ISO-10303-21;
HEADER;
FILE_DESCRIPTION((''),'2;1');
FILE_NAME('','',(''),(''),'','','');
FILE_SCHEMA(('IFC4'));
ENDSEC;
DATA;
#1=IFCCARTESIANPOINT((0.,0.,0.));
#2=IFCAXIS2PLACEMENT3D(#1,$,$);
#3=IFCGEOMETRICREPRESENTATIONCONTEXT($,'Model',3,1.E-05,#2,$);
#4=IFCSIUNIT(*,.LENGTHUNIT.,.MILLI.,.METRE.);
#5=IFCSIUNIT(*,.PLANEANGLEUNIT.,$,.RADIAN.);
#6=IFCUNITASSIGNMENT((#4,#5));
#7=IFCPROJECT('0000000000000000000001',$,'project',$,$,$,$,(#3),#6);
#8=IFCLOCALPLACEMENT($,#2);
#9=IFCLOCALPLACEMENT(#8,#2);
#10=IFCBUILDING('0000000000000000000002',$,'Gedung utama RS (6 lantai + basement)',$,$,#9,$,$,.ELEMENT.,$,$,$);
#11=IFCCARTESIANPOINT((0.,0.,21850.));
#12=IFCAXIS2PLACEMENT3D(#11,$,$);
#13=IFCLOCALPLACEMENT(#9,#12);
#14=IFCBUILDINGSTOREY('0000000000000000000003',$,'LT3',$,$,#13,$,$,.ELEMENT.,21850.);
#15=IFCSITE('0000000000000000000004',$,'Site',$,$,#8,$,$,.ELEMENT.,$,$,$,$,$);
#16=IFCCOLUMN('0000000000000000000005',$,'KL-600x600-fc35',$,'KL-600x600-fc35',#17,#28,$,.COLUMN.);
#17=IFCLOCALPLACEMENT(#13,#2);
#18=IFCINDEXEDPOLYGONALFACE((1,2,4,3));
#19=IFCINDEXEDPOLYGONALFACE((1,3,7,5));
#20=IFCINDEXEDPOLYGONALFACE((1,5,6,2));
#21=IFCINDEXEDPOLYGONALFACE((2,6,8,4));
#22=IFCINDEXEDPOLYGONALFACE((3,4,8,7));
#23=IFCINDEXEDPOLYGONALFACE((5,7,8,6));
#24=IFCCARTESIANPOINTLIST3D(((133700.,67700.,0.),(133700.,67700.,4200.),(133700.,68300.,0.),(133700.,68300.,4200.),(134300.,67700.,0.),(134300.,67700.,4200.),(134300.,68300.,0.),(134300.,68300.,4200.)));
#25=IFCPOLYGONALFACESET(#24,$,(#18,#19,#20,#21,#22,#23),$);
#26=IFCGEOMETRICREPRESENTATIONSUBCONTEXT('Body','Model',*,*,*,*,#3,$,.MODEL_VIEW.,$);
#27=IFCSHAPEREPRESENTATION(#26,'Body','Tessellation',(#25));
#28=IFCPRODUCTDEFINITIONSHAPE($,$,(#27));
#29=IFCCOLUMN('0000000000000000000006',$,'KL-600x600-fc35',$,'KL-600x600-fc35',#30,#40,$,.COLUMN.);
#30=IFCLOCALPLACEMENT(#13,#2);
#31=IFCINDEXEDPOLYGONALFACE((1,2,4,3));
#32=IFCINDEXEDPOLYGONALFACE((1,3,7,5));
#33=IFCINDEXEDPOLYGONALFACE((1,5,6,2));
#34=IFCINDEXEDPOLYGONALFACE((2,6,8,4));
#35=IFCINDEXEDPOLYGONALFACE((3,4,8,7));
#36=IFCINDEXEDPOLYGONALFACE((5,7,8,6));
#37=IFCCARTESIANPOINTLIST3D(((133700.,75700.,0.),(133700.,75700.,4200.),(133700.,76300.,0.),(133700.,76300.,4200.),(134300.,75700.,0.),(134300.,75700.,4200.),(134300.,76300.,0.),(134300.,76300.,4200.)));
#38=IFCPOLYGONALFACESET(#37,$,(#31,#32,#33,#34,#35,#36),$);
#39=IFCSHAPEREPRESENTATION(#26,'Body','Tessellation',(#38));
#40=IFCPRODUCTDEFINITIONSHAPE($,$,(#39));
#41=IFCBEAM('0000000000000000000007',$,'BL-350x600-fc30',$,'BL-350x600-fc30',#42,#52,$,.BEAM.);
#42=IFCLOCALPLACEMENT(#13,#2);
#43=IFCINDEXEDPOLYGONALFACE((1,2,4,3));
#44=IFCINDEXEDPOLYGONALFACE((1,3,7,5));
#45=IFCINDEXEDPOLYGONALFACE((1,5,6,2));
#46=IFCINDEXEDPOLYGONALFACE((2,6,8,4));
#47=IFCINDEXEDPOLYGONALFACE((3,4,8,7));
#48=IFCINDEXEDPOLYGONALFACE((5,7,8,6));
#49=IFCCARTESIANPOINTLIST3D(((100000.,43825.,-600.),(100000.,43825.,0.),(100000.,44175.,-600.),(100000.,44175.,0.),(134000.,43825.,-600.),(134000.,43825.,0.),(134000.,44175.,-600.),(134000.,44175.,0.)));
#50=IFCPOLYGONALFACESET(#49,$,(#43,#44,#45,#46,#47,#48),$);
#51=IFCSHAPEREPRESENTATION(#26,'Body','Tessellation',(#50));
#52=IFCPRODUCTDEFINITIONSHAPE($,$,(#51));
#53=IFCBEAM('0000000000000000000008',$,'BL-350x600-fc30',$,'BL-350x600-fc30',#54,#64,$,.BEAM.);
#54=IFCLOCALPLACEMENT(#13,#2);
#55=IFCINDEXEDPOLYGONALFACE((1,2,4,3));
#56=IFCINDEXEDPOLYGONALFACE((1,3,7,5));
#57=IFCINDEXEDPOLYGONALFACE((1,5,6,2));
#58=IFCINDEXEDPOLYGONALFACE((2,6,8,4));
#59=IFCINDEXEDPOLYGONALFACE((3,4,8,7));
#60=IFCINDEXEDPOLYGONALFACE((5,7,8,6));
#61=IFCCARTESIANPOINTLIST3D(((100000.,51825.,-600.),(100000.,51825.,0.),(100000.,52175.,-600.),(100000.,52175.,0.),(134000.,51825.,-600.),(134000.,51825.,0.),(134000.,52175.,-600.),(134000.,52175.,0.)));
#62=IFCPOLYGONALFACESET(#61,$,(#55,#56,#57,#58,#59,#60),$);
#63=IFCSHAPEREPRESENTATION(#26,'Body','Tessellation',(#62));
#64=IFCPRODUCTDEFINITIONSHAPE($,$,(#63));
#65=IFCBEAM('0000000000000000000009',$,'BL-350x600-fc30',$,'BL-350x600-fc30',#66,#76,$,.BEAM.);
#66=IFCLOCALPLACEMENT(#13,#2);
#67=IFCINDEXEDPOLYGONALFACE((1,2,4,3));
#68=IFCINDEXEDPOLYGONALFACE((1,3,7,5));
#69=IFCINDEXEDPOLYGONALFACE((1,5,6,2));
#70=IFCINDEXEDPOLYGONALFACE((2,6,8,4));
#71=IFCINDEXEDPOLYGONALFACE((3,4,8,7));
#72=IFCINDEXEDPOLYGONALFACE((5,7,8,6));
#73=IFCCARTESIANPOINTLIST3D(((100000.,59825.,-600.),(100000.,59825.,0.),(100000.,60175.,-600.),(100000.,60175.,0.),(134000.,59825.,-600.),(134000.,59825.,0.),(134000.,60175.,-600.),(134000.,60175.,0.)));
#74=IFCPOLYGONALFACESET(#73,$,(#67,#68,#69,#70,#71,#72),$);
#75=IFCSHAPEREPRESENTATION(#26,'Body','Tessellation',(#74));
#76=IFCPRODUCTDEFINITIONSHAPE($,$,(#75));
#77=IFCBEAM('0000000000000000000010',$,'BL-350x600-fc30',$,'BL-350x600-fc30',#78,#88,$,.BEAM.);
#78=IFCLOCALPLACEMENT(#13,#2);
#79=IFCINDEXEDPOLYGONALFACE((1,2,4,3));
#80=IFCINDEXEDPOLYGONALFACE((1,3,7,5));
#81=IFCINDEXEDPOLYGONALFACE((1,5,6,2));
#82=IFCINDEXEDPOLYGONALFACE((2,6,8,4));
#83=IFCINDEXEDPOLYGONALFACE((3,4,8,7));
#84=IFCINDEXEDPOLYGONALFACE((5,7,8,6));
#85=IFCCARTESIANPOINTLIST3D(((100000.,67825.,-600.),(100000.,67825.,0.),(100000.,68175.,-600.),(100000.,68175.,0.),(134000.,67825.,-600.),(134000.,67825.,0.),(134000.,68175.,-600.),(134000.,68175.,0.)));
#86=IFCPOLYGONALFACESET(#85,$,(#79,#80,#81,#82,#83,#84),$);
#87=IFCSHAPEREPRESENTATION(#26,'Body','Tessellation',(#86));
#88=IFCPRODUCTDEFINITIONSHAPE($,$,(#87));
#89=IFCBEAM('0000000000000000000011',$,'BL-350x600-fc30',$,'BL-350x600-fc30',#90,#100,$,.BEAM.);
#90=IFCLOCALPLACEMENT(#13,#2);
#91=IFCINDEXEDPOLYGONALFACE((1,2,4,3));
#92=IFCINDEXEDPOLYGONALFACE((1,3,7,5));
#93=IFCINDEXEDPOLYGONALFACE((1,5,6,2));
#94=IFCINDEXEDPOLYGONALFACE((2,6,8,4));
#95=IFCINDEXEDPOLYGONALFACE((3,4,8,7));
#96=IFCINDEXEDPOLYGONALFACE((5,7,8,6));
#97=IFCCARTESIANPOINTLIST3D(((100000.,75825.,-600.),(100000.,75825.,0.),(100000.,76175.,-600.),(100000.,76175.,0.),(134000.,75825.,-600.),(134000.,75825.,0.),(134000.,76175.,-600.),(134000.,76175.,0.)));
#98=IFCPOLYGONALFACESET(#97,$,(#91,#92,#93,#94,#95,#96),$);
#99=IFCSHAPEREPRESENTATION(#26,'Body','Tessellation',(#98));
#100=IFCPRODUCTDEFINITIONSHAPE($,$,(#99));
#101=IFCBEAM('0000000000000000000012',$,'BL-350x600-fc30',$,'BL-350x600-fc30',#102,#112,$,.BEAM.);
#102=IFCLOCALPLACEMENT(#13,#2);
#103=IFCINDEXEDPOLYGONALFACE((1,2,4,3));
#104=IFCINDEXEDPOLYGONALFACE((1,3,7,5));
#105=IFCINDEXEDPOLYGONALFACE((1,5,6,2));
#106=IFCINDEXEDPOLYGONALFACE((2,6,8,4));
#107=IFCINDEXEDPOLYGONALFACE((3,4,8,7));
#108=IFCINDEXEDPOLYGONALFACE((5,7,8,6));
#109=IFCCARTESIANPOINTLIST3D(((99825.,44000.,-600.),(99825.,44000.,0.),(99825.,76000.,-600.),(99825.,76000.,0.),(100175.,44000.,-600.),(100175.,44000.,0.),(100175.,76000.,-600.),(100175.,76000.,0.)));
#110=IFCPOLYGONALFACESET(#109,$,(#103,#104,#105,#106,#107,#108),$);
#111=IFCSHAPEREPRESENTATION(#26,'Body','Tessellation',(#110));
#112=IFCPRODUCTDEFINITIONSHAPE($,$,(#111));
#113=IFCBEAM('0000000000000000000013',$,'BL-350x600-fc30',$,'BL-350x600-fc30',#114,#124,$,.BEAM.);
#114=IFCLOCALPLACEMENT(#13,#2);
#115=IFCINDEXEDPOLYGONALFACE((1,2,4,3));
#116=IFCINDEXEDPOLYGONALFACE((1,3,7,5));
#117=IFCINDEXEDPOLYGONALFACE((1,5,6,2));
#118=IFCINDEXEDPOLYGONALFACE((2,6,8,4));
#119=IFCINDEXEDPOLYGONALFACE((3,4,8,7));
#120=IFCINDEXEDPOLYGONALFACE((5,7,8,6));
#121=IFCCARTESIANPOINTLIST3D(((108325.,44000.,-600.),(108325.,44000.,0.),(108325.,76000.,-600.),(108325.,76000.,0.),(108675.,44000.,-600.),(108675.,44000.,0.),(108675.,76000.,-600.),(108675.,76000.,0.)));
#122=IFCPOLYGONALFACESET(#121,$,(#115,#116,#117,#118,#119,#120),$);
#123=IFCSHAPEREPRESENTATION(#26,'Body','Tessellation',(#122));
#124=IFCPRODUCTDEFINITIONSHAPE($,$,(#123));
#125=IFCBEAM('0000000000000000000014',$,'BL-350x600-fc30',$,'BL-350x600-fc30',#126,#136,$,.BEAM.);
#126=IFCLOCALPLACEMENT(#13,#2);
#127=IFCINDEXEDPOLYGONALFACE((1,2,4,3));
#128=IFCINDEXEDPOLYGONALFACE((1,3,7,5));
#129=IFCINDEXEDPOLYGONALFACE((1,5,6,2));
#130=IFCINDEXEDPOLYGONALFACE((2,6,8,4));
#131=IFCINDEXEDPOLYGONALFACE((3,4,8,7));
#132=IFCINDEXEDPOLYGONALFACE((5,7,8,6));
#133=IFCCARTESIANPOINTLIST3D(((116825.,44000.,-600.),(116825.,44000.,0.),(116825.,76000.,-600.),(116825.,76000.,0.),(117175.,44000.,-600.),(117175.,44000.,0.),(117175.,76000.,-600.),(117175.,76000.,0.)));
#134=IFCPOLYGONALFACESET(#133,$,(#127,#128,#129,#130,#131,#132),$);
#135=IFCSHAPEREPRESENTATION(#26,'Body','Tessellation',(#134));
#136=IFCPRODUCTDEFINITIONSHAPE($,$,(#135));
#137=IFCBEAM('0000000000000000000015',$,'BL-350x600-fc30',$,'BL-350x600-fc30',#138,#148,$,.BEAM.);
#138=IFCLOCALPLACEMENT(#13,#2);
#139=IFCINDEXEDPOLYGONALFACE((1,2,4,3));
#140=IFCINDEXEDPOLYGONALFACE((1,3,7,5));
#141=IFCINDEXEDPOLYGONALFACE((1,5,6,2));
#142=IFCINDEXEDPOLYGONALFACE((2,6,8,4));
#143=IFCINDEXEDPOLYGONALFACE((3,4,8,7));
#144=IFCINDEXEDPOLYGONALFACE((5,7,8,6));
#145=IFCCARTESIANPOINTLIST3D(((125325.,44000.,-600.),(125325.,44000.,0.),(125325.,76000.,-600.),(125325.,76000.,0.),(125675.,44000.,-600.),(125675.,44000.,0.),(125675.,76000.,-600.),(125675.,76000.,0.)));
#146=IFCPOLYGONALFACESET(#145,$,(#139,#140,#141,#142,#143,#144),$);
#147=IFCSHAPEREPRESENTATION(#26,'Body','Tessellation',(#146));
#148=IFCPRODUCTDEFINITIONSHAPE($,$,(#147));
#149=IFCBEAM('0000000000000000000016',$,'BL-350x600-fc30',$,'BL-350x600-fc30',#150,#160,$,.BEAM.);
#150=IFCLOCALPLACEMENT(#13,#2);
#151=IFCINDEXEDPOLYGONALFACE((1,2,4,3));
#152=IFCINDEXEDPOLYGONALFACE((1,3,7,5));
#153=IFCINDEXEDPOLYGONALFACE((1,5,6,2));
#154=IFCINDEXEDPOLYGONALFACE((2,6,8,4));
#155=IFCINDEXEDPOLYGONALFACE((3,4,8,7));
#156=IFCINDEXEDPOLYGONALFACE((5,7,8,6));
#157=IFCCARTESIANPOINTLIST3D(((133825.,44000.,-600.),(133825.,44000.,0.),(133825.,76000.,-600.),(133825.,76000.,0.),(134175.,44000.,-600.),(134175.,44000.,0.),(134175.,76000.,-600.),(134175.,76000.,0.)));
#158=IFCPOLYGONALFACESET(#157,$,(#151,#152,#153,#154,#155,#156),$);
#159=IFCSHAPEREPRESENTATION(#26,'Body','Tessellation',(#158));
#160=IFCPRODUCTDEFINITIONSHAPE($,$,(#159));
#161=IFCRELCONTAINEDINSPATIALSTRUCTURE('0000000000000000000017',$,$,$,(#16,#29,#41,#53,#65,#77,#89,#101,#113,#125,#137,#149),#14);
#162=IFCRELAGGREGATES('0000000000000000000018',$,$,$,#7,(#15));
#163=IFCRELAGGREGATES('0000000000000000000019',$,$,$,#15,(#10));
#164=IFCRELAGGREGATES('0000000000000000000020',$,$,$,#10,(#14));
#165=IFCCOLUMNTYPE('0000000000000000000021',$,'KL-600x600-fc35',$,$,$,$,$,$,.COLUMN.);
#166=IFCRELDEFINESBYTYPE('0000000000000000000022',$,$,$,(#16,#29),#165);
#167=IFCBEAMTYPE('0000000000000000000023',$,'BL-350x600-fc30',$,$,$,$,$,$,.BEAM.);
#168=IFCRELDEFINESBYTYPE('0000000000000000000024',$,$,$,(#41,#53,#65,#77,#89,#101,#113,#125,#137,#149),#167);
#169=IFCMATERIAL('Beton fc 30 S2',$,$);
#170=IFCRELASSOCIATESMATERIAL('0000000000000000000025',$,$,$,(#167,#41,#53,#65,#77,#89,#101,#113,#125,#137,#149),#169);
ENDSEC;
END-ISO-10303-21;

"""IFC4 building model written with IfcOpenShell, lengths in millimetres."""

from ifc_helpers import new_model, si_unit, frame, origin, origin_2d, place, context, subcontext, project, spatial, rectangle, extrude, material, material_profile, profile_set, profile_usage, type_object, element, save


model = new_model("IFC4")

# Units and contexts
model_context = context("Model", 3, precision=1e-05, world=origin())
body_context = subcontext(model_context, "Body", "Model", "MODEL_VIEW")
ifc_project = project(units=[si_unit("LENGTHUNIT", "METRE", prefix="MILLI"), si_unit("PLANEANGLEUNIT", "RADIAN")], contexts=[model_context])

# Site, building, storey
site_placement = place(None, origin())
site = spatial("IfcSite", under=ifc_project, at=site_placement, Name="Site", CompositionType="ELEMENT")
building_placement = place(site_placement, origin())
building = spatial("IfcBuilding", under=site, at=building_placement, Name="Gedung utama RS (6 lantai + basement)", CompositionType="ELEMENT")
storey_placement = place(building_placement, frame((0.0, 0.0, 21850.0)))
storey = spatial("IfcBuildingStorey", under=building, at=storey_placement, Name="LT3", CompositionType="ELEMENT", Elevation=21850.0)

# Columns
ifc_material_profile_1 = material_profile(None, rectangle(XDim=600.0, YDim=600.0, at=origin_2d()), Name="KL-600x600-fc35")
ifc_profile_set_1 = profile_set([ifc_material_profile_1], Name="KL-600x600-fc35")
ifc_profile_usage_1 = profile_usage(ifc_profile_set_1, cardinal=5)
column_type = type_object("IfcColumnType", Name="KL-600x600-fc35", PredefinedType="COLUMN", material=ifc_profile_set_1)
for number, where, z_axis, x_axis, name in (
    (1, (134000.0, 68000.0, 0.0), (0.0, 0.0, 1.0), (1.0, 0.0, 0.0), "KL-600x600-fc35"),
    (2, (134000.0, 76000.0, 0.0), (0.0, 0.0, 1.0), (1.0, 0.0, 0.0), "KL-600x600-fc35"),
):
    element("IfcColumn", number, at=place(storey_placement, frame(where, z_axis=z_axis, x_axis=x_axis)), inside=storey, type_object=column_type, material=ifc_profile_usage_1, Name=name, ObjectType="KL-600x600-fc35", PredefinedType="COLUMN", context=body_context, shape_type="SweptSolid", body=[
        extrude(rectangle(XDim=600.0, YDim=600.0, at=origin_2d()), origin(), (0.0, 0.0, 1.0), 4200.0),
    ])

# Beams
ifc_material = material(Name="Beton fc 30 S2")
ifc_material_profile_2 = material_profile(ifc_material, rectangle(XDim=350.0, YDim=600.0, at=origin_2d()), Name="BL-350x600-fc30")
ifc_profile_set_2 = profile_set([ifc_material_profile_2], Name="BL-350x600-fc30")
ifc_profile_usage_2 = profile_usage(ifc_profile_set_2, cardinal=8)
beam_type = type_object("IfcBeamType", Name="BL-350x600-fc30", PredefinedType="BEAM", material=ifc_profile_set_2)
for number, where, name in (
    (3, (100000.0, 44000.0, -300.0), "BL-350x600-fc30"),
    (4, (100000.0, 52000.0, -300.0), "BL-350x600-fc30"),
    (5, (100000.0, 60000.0, -300.0), "BL-350x600-fc30"),
    (6, (100000.0, 68000.0, -300.0), "BL-350x600-fc30"),
    (7, (100000.0, 76000.0, -300.0), "BL-350x600-fc30"),
):
    element("IfcBeam", number, at=place(storey_placement, frame(where)), inside=storey, type_object=beam_type, material=ifc_profile_usage_2, Name=name, ObjectType="BL-350x600-fc30", PredefinedType="BEAM", context=body_context, shape_type="SweptSolid", body=[
        extrude(rectangle(XDim=350.0, YDim=600.0, at=origin_2d()), frame((0.0, 0.0, 0.0), z_axis=(1.0, 0.0, 0.0), x_axis=(0.0, 1.0, 0.0)), (0.0, 0.0, 1.0), 34000.0),
    ])
for number, where, name in (
    (8, (100000.0, 44000.0, -300.0), "BL-350x600-fc30"),
    (9, (108500.0, 44000.0, -300.0), "BL-350x600-fc30"),
    (10, (117000.0, 44000.0, -300.0), "BL-350x600-fc30"),
    (11, (125500.0, 44000.0, -300.0), "BL-350x600-fc30"),
    (12, (134000.0, 44000.0, -300.0), "BL-350x600-fc30"),
):
    element("IfcBeam", number, at=place(storey_placement, frame(where)), inside=storey, type_object=beam_type, material=ifc_profile_usage_2, Name=name, ObjectType="BL-350x600-fc30", PredefinedType="BEAM", context=body_context, shape_type="SweptSolid", body=[
        extrude(rectangle(XDim=350.0, YDim=600.0, at=origin_2d()), frame((0.0, 0.0, 0.0), z_axis=(0.0, 1.0, 0.0), x_axis=(-1.0, 0.0, 0.0)), (0.0, 0.0, 1.0), 32000.0),
    ])

save(model, "model.ifc")
